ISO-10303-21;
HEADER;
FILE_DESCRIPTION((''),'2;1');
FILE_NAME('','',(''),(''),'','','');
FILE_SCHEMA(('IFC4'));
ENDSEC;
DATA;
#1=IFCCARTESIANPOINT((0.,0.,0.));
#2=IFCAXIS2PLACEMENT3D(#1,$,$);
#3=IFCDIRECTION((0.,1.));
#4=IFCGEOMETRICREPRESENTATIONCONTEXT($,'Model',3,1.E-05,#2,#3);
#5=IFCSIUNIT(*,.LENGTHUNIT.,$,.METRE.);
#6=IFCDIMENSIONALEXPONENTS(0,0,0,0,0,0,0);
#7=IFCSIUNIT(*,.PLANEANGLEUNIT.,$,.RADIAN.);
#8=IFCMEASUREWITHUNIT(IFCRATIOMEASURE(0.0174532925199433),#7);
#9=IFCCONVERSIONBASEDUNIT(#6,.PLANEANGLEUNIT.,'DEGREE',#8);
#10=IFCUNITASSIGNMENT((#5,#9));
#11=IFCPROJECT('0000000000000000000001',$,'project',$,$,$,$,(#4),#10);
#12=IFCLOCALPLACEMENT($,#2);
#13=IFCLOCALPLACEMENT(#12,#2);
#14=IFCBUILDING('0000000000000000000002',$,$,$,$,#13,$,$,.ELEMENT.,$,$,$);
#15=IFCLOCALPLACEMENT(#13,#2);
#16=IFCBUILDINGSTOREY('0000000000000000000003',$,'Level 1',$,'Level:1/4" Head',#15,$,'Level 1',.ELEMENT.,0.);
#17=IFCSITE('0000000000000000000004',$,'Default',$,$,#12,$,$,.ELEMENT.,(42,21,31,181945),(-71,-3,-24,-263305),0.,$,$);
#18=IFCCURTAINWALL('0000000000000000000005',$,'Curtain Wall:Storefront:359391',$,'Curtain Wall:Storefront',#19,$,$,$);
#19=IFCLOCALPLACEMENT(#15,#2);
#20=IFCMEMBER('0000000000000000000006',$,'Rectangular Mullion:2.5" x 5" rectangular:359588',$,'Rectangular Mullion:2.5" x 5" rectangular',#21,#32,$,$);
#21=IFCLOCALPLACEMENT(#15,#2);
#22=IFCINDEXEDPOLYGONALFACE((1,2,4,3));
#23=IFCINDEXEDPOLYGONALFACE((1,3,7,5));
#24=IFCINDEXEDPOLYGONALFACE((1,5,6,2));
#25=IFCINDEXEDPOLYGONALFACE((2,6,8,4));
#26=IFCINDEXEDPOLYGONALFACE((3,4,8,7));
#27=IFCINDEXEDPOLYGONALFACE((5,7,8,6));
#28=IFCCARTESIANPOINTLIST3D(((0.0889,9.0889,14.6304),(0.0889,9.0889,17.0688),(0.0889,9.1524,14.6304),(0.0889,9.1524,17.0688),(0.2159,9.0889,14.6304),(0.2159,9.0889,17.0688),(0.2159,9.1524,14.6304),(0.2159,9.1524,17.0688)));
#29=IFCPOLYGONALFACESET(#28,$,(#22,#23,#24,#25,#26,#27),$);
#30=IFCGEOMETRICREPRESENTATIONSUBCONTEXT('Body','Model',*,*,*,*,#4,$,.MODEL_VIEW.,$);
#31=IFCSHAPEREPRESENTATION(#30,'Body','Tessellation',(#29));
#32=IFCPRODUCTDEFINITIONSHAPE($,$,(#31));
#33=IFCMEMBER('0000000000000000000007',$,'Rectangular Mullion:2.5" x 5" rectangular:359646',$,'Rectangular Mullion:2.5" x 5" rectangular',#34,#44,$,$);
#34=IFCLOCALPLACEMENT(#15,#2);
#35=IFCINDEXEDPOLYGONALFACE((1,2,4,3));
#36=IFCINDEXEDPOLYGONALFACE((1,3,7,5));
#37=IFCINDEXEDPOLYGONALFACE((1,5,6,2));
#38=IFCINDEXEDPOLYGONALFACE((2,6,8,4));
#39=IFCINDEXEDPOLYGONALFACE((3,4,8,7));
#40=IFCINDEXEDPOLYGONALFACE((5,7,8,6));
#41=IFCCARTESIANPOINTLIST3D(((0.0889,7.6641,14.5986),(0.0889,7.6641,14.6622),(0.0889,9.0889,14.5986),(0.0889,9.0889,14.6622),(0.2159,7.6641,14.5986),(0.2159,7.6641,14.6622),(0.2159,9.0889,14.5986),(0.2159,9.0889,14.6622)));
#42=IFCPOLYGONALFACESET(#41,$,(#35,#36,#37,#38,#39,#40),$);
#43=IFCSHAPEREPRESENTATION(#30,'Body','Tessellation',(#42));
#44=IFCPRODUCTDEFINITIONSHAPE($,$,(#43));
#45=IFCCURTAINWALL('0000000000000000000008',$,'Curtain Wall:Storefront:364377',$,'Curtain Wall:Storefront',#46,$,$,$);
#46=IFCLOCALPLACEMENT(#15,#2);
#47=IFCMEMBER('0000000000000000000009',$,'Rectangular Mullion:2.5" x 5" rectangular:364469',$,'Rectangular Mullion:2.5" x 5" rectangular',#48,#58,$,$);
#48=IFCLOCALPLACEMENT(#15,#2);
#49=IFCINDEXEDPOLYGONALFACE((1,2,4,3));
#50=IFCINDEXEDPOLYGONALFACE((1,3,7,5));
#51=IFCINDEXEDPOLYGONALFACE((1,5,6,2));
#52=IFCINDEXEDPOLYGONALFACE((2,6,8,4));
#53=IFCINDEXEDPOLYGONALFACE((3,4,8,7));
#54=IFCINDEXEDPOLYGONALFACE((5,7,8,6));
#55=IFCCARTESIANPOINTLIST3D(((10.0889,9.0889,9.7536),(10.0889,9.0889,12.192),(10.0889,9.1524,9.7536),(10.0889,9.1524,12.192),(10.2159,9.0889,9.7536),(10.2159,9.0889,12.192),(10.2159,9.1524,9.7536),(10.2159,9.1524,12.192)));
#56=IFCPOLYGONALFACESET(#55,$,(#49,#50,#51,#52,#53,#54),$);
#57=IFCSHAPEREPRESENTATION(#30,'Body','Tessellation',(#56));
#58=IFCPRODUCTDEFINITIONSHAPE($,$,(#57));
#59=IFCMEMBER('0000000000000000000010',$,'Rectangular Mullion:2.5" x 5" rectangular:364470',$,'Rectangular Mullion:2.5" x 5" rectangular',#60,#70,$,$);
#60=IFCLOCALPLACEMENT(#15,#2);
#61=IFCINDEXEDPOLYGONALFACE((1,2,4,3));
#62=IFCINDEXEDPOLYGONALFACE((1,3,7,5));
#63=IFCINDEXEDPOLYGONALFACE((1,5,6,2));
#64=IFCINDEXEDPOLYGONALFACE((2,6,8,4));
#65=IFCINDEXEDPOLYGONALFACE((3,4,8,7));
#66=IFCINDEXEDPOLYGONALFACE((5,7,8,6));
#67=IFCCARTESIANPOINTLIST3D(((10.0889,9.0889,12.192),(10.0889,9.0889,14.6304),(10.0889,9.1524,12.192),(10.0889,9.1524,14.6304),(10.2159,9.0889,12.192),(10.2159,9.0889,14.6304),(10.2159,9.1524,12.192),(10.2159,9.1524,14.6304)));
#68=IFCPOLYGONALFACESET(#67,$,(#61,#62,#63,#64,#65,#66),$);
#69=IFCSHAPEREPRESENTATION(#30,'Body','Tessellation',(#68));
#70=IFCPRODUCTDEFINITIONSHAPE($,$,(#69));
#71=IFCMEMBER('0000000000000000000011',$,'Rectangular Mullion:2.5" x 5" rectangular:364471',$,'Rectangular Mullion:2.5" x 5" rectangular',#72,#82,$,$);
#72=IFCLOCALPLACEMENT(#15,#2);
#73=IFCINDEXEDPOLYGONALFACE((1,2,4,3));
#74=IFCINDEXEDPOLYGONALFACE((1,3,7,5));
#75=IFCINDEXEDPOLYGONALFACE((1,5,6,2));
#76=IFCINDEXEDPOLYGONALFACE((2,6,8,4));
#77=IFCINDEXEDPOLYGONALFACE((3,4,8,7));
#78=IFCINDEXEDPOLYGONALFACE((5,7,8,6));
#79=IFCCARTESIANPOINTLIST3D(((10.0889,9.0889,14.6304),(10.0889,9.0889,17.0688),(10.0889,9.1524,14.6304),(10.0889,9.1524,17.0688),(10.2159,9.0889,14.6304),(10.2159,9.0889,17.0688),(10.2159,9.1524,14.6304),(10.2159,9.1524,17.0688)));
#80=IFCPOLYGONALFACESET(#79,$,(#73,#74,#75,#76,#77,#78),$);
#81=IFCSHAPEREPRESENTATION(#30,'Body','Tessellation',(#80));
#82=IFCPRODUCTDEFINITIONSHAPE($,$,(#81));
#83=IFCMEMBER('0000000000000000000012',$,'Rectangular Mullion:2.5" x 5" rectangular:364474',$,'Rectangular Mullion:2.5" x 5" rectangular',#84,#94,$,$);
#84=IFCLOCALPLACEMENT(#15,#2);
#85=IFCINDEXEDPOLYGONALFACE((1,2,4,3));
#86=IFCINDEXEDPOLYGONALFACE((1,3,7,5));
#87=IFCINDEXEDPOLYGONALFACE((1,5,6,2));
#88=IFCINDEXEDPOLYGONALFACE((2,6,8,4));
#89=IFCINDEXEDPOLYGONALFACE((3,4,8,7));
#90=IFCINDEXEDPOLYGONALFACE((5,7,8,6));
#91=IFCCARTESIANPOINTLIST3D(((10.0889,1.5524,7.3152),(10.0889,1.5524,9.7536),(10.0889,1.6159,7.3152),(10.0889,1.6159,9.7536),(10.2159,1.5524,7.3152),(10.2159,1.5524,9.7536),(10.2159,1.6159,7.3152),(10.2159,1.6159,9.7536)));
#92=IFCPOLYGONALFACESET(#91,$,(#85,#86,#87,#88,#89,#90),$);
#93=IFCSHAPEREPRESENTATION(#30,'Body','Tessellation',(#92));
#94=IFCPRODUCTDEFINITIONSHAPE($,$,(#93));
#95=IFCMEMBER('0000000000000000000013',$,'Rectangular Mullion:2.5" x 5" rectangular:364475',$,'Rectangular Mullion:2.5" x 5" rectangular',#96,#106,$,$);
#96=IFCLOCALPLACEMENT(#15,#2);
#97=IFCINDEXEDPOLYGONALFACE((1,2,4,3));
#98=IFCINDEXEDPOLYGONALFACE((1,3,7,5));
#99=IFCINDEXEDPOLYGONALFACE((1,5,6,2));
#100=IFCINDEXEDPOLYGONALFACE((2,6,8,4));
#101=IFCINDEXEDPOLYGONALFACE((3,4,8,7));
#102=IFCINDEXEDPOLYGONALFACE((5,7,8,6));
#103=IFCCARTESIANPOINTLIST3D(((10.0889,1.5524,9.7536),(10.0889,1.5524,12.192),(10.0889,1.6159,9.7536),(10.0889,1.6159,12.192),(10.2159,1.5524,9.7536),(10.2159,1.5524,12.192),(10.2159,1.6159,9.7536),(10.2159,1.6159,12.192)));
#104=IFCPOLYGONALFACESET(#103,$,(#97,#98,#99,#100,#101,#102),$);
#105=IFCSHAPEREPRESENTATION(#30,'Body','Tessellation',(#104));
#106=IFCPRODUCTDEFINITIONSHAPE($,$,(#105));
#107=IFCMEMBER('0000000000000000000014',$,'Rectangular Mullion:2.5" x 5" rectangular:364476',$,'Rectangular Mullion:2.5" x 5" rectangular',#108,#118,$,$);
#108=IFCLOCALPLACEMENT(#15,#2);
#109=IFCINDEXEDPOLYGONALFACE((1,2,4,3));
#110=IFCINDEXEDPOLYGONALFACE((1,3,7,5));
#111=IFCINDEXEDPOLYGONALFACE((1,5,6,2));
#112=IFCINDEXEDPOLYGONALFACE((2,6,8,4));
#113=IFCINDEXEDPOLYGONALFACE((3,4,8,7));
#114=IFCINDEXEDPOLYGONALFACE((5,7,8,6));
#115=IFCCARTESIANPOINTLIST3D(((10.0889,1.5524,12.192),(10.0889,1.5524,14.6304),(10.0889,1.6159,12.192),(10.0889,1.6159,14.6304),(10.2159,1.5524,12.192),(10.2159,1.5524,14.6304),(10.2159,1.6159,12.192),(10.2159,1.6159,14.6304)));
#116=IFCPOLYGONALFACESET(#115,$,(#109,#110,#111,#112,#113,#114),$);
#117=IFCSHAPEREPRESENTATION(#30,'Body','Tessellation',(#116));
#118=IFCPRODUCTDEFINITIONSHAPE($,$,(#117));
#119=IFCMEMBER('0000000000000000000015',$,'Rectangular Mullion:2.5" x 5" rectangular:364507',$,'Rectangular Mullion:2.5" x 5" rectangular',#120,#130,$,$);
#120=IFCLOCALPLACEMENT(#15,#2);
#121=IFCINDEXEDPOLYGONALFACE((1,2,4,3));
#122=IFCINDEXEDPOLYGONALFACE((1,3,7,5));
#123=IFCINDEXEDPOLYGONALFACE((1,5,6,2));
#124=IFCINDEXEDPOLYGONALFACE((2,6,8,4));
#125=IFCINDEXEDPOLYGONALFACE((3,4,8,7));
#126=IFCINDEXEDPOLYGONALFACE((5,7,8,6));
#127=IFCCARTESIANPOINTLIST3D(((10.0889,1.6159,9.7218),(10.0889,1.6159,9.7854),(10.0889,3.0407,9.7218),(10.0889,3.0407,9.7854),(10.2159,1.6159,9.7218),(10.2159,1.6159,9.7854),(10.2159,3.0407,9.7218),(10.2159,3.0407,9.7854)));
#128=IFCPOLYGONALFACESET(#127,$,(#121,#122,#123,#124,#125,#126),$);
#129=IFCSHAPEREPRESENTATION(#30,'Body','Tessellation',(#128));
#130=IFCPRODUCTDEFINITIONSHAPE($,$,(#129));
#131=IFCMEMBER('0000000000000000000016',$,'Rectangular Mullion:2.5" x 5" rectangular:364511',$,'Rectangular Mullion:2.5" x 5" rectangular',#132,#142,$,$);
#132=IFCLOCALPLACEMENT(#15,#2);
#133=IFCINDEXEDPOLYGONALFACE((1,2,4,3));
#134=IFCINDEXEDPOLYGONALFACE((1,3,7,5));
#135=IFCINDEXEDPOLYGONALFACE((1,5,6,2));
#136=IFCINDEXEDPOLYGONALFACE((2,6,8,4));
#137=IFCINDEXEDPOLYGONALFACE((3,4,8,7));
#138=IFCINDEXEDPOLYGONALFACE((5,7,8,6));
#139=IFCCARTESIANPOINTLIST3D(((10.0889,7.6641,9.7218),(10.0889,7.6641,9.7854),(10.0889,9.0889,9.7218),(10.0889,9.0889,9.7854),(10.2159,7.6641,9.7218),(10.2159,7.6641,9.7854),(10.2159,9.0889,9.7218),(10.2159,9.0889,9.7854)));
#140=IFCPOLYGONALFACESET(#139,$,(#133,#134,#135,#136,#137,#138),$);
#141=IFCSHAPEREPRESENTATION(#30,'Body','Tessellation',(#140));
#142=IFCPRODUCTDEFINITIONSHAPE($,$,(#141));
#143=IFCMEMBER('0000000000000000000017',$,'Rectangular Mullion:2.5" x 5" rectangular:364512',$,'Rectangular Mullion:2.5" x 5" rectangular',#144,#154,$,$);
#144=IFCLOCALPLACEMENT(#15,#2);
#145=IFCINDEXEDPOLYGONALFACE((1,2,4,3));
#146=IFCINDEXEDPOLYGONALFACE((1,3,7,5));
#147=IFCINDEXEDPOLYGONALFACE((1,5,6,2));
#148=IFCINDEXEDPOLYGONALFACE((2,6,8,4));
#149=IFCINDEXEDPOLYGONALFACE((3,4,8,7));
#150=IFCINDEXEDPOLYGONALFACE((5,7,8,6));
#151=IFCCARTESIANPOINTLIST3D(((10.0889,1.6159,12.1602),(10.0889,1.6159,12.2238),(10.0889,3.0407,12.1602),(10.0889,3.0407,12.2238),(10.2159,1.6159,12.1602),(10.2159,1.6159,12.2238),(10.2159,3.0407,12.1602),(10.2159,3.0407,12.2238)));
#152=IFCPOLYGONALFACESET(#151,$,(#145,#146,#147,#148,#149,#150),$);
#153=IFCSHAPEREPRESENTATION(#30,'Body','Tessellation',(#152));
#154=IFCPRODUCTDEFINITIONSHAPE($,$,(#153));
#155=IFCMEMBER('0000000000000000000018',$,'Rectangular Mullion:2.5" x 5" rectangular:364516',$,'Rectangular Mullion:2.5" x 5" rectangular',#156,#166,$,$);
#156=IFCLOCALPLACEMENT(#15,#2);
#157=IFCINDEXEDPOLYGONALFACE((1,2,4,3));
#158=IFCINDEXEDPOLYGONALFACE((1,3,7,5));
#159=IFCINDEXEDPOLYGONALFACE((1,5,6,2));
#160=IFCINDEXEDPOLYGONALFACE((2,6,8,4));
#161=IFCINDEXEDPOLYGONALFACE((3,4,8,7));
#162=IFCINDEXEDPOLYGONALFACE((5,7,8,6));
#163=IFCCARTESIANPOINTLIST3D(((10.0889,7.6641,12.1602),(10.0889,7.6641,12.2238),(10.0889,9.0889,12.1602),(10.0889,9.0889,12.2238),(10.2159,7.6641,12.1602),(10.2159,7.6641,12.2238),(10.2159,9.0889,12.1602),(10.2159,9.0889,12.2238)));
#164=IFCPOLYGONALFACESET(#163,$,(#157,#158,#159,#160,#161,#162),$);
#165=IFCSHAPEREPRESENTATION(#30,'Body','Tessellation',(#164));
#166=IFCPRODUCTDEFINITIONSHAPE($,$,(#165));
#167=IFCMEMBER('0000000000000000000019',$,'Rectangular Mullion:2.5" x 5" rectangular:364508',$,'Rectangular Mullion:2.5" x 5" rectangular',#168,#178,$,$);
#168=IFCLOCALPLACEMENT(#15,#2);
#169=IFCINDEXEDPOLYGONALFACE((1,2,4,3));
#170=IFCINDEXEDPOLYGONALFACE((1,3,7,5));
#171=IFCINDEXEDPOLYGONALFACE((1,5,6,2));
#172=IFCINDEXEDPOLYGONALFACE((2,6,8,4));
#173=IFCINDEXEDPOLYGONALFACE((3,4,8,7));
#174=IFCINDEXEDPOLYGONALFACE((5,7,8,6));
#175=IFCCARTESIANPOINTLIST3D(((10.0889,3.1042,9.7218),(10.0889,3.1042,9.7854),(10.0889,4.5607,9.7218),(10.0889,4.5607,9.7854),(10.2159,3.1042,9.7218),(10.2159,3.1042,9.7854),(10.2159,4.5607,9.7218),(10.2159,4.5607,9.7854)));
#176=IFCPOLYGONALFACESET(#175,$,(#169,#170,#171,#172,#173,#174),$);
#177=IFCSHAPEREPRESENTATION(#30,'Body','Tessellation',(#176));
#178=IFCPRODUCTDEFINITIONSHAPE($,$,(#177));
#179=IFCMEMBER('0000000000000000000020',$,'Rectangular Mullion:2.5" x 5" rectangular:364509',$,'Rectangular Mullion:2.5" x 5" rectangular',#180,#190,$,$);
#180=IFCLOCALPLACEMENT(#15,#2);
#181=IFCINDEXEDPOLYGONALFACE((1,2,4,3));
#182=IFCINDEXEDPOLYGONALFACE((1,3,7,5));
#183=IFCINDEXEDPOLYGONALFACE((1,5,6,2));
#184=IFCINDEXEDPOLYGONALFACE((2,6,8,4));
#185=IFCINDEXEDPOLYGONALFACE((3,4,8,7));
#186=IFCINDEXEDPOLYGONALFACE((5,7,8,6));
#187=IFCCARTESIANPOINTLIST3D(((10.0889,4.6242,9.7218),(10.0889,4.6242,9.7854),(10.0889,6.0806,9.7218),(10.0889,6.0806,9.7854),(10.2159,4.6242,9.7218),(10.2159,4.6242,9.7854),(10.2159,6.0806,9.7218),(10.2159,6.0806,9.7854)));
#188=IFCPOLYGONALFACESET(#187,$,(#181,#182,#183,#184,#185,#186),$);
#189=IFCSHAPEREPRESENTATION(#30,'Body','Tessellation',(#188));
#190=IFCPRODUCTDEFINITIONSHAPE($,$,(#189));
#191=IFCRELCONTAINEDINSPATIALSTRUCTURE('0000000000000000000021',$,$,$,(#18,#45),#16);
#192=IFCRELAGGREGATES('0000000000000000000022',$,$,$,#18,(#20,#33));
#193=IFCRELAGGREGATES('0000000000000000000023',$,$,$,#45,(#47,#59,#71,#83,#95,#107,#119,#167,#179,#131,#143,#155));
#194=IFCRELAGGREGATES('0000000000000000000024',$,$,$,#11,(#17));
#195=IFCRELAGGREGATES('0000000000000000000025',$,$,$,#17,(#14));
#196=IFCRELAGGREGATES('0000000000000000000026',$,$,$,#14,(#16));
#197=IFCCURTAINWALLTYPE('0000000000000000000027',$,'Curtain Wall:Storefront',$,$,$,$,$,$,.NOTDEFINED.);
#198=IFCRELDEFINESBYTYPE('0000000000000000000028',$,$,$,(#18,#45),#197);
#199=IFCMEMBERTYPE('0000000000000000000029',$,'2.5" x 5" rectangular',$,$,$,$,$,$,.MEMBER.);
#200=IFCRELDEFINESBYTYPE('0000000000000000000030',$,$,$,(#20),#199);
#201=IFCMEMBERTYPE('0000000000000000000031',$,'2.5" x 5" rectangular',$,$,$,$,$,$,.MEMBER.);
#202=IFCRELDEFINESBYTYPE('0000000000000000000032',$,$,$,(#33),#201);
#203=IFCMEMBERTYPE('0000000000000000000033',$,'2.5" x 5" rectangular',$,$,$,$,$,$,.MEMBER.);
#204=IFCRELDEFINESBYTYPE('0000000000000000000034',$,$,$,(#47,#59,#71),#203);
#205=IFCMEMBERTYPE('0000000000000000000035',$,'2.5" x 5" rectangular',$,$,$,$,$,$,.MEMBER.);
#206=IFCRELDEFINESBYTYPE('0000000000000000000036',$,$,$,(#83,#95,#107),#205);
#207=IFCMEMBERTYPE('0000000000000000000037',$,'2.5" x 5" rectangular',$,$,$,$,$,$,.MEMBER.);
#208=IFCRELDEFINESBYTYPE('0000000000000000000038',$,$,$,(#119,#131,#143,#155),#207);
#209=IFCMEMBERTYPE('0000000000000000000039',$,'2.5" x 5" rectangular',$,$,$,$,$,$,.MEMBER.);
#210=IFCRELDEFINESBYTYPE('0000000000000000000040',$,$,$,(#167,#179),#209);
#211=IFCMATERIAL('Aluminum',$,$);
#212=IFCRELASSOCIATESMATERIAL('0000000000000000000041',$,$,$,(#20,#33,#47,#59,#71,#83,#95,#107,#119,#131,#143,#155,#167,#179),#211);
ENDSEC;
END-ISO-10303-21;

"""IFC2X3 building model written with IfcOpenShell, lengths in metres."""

from ifc_helpers import new_model, entity, si_unit, converted_unit, direction, frame, origin, origin_2d_with_axis, place, context, subcontext, project, spatial, rectangle, extrude, source, transform, mapped, material, type_object, type_shapes, element, aggregate, save


model = new_model("IFC2X3")

# Units and contexts
model_context = context("Model", 3, precision=1e-05, world=origin(), true_north=direction((0.0, 1.0)))
body_context = subcontext(model_context, "Body", "Model", "MODEL_VIEW")
ifc_project = project(units=[si_unit("LENGTHUNIT", "METRE"), converted_unit("PLANEANGLEUNIT", "DEGREE", entity("IfcRatioMeasure", 0.0174532925199433), si_unit("PLANEANGLEUNIT", "RADIAN"), dimensions=[0, 0, 0, 0, 0, 0, 0])], contexts=[model_context])

# Site, building, storey
site_placement = place(None, origin())
site = spatial("IfcSite", under=ifc_project, at=site_placement, Name="Default", CompositionType="ELEMENT", RefLatitude=(42, 21, 31, 181945), RefLongitude=(-71, -3, -24, -263305), RefElevation=0.0)
building_placement = place(site_placement, origin())
building = spatial("IfcBuilding", under=site, at=building_placement, CompositionType="ELEMENT")
storey_placement = place(building_placement, origin())
storey = spatial("IfcBuildingStorey", under=building, at=storey_placement, Name="Level 1", ObjectType="Level:1/4\" Head", LongName="Level 1", CompositionType="ELEMENT", Elevation=0.0)

# Curtain wall, members
curtain_wall_type = type_object("IfcCurtainWallType", Name="Curtain Wall:Storefront", PredefinedType="NOTDEFINED")
curtain_wall_1_placement = place(storey_placement, origin())
curtain_wall_1 = element("IfcCurtainWall", 1, at=curtain_wall_1_placement, inside=storey, type_object=curtain_wall_type, Name="Curtain Wall:Storefront:359391", ObjectType="Curtain Wall:Storefront")
ifc_material_1 = material(Name="Aluminum")
member_type_1 = type_object("IfcMemberType", Name="2.5\" x 5\" rectangular", PredefinedType="MEMBER")
shared_shape_1 = source(origin(), body_context, "Body", "SweptSolid", [
    extrude(rectangle(XDim=0.127, YDim=0.0635, at=origin_2d_with_axis()), frame((-0.0318, 0.0, -2.4384), z_axis=(0.0, 0.0, 1.0), x_axis=(0.0, -1.0, 0.0)), (0.0, 0.0, 1.0), 2.4384),
])
type_shapes(member_type_1, [shared_shape_1])
member_1_placement = place(storey_placement, frame((0.1524, 9.1524, 14.6304), z_axis=(0.0, 0.0, -1.0), x_axis=(0.0, 1.0, 0.0)))
member_1 = element("IfcMember", 2, at=member_1_placement, type_object=member_type_1, material=ifc_material_1, Name="Rectangular Mullion:2.5\" x 5\" rectangular:359588", ObjectType="Rectangular Mullion:2.5\" x 5\" rectangular", context=body_context, shape_type="MappedRepresentation", body=[
    mapped(shared_shape_1, transform((0.0, 0.0, 0.0), scale=1.0)),
])
member_type_2 = type_object("IfcMemberType", Name="2.5\" x 5\" rectangular", PredefinedType="MEMBER")
shared_shape_2 = source(origin(), body_context, "Body", "SweptSolid", [
    extrude(rectangle(XDim=0.127, YDim=0.0635, at=origin_2d_with_axis()), frame((0.0, 0.0, -1.4248), z_axis=(0.0, 0.0, 1.0), x_axis=(0.0, -1.0, 0.0)), (0.0, 0.0, 1.0), 1.4248),
])
type_shapes(member_type_2, [shared_shape_2])
member_2_placement = place(storey_placement, frame((0.1524, 9.0889, 14.6304), z_axis=(0.0, 1.0, 0.0), x_axis=(0.0, 0.0, 1.0)))
member_2 = element("IfcMember", 3, at=member_2_placement, type_object=member_type_2, material=ifc_material_1, Name="Rectangular Mullion:2.5\" x 5\" rectangular:359646", ObjectType="Rectangular Mullion:2.5\" x 5\" rectangular", context=body_context, shape_type="MappedRepresentation", body=[
    mapped(shared_shape_2, transform((0.0, 0.0, 0.0), scale=1.0)),
])
aggregate(curtain_wall_1, [member_1, member_2])

# Curtain wall, members
curtain_wall_2_placement = place(storey_placement, origin())
curtain_wall_2 = element("IfcCurtainWall", 4, at=curtain_wall_2_placement, inside=storey, type_object=curtain_wall_type, Name="Curtain Wall:Storefront:364377", ObjectType="Curtain Wall:Storefront")
member_type_3 = type_object("IfcMemberType", Name="2.5\" x 5\" rectangular", PredefinedType="MEMBER")
shared_shape_3 = source(origin(), body_context, "Body", "SweptSolid", [
    extrude(rectangle(XDim=0.127, YDim=0.0635, at=origin_2d_with_axis()), frame((-0.0318, 0.0, -2.4384), z_axis=(0.0, 0.0, 1.0), x_axis=(0.0, -1.0, 0.0)), (0.0, 0.0, 1.0), 2.4384),
])
type_shapes(member_type_3, [shared_shape_3])
member_3_placement = place(storey_placement, frame((10.1524, 9.1524, 9.7536), z_axis=(0.0, 0.0, -1.0), x_axis=(0.0, 1.0, 0.0)))
member_3 = element("IfcMember", 5, at=member_3_placement, type_object=member_type_3, material=ifc_material_1, Name="Rectangular Mullion:2.5\" x 5\" rectangular:364469", ObjectType="Rectangular Mullion:2.5\" x 5\" rectangular", context=body_context, shape_type="MappedRepresentation", body=[
    mapped(shared_shape_3, transform((0.0, 0.0, 0.0), scale=1.0)),
])
member_4_placement = place(storey_placement, frame((10.1524, 9.1524, 12.192), z_axis=(0.0, 0.0, -1.0), x_axis=(0.0, 1.0, 0.0)))
member_4 = element("IfcMember", 6, at=member_4_placement, type_object=member_type_3, material=ifc_material_1, Name="Rectangular Mullion:2.5\" x 5\" rectangular:364470", ObjectType="Rectangular Mullion:2.5\" x 5\" rectangular", context=body_context, shape_type="MappedRepresentation", body=[
    mapped(shared_shape_3, transform((0.0, 0.0, 0.0), scale=1.0)),
])
member_5_placement = place(storey_placement, frame((10.1524, 9.1524, 14.6304), z_axis=(0.0, 0.0, -1.0), x_axis=(0.0, 1.0, 0.0)))
member_5 = element("IfcMember", 7, at=member_5_placement, type_object=member_type_3, material=ifc_material_1, Name="Rectangular Mullion:2.5\" x 5\" rectangular:364471", ObjectType="Rectangular Mullion:2.5\" x 5\" rectangular", context=body_context, shape_type="MappedRepresentation", body=[
    mapped(shared_shape_3, transform((0.0, 0.0, 0.0), scale=1.0)),
])
member_type_4 = type_object("IfcMemberType", Name="2.5\" x 5\" rectangular", PredefinedType="MEMBER")
shared_shape_4 = source(origin(), body_context, "Body", "SweptSolid", [
    extrude(rectangle(XDim=0.127, YDim=0.0635, at=origin_2d_with_axis()), frame((-0.0318, 0.0, -2.4384), z_axis=(0.0, 0.0, 1.0), x_axis=(0.0, -1.0, 0.0)), (0.0, 0.0, 1.0), 2.4384),
])
type_shapes(member_type_4, [shared_shape_4])
member_6_placement = place(storey_placement, frame((10.1524, 1.5524, 9.7536), z_axis=(0.0, 0.0, 1.0), x_axis=(0.0, -1.0, 0.0)))
member_6 = element("IfcMember", 8, at=member_6_placement, type_object=member_type_4, material=ifc_material_1, Name="Rectangular Mullion:2.5\" x 5\" rectangular:364474", ObjectType="Rectangular Mullion:2.5\" x 5\" rectangular", context=body_context, shape_type="MappedRepresentation", body=[
    mapped(shared_shape_4, transform((0.0, 0.0, 0.0), scale=1.0)),
])
member_7_placement = place(storey_placement, frame((10.1524, 1.5524, 12.192), z_axis=(0.0, 0.0, 1.0), x_axis=(0.0, -1.0, 0.0)))
member_7 = element("IfcMember", 9, at=member_7_placement, type_object=member_type_4, material=ifc_material_1, Name="Rectangular Mullion:2.5\" x 5\" rectangular:364475", ObjectType="Rectangular Mullion:2.5\" x 5\" rectangular", context=body_context, shape_type="MappedRepresentation", body=[
    mapped(shared_shape_4, transform((0.0, 0.0, 0.0), scale=1.0)),
])
member_8_placement = place(storey_placement, frame((10.1524, 1.5524, 14.6304), z_axis=(0.0, 0.0, 1.0), x_axis=(0.0, -1.0, 0.0)))
member_8 = element("IfcMember", 10, at=member_8_placement, type_object=member_type_4, material=ifc_material_1, Name="Rectangular Mullion:2.5\" x 5\" rectangular:364476", ObjectType="Rectangular Mullion:2.5\" x 5\" rectangular", context=body_context, shape_type="MappedRepresentation", body=[
    mapped(shared_shape_4, transform((0.0, 0.0, 0.0), scale=1.0)),
])
member_type_5 = type_object("IfcMemberType", Name="2.5\" x 5\" rectangular", PredefinedType="MEMBER")
shared_shape_5 = source(origin(), body_context, "Body", "SweptSolid", [
    extrude(rectangle(XDim=0.127, YDim=0.0635, at=origin_2d_with_axis()), frame((0.0, 0.0, -1.4248), z_axis=(0.0, 0.0, 1.0), x_axis=(0.0, -1.0, 0.0)), (0.0, 0.0, 1.0), 1.4248),
])
type_shapes(member_type_5, [shared_shape_5])
member_9_placement = place(storey_placement, frame((10.1524, 3.0407, 9.7536), z_axis=(0.0, 1.0, 0.0), x_axis=(0.0, 0.0, 1.0)))
member_9 = element("IfcMember", 11, at=member_9_placement, type_object=member_type_5, material=ifc_material_1, Name="Rectangular Mullion:2.5\" x 5\" rectangular:364507", ObjectType="Rectangular Mullion:2.5\" x 5\" rectangular", context=body_context, shape_type="MappedRepresentation", body=[
    mapped(shared_shape_5, transform((0.0, 0.0, 0.0), scale=1.0)),
])
member_10_placement = place(storey_placement, frame((10.1524, 9.0889, 9.7536), z_axis=(0.0, 1.0, 0.0), x_axis=(0.0, 0.0, 1.0)))
member_10 = element("IfcMember", 12, at=member_10_placement, type_object=member_type_5, material=ifc_material_1, Name="Rectangular Mullion:2.5\" x 5\" rectangular:364511", ObjectType="Rectangular Mullion:2.5\" x 5\" rectangular", context=body_context, shape_type="MappedRepresentation", body=[
    mapped(shared_shape_5, transform((0.0, 0.0, 0.0), scale=1.0)),
])
member_11_placement = place(storey_placement, frame((10.1524, 3.0407, 12.192), z_axis=(0.0, 1.0, 0.0), x_axis=(0.0, 0.0, 1.0)))
member_11 = element("IfcMember", 13, at=member_11_placement, type_object=member_type_5, material=ifc_material_1, Name="Rectangular Mullion:2.5\" x 5\" rectangular:364512", ObjectType="Rectangular Mullion:2.5\" x 5\" rectangular", context=body_context, shape_type="MappedRepresentation", body=[
    mapped(shared_shape_5, transform((0.0, 0.0, 0.0), scale=1.0)),
])
member_12_placement = place(storey_placement, frame((10.1524, 9.0889, 12.192), z_axis=(0.0, 1.0, 0.0), x_axis=(0.0, 0.0, 1.0)))
member_12 = element("IfcMember", 14, at=member_12_placement, type_object=member_type_5, material=ifc_material_1, Name="Rectangular Mullion:2.5\" x 5\" rectangular:364516", ObjectType="Rectangular Mullion:2.5\" x 5\" rectangular", context=body_context, shape_type="MappedRepresentation", body=[
    mapped(shared_shape_5, transform((0.0, 0.0, 0.0), scale=1.0)),
])
member_type_6 = type_object("IfcMemberType", Name="2.5\" x 5\" rectangular", PredefinedType="MEMBER")
shared_shape_6 = source(origin(), body_context, "Body", "SweptSolid", [
    extrude(rectangle(XDim=0.127, YDim=0.0635, at=origin_2d_with_axis()), frame((0.0, 0.0, -1.4565), z_axis=(0.0, 0.0, 1.0), x_axis=(0.0, -1.0, 0.0)), (0.0, 0.0, 1.0), 1.4565),
])
type_shapes(member_type_6, [shared_shape_6])
member_13_placement = place(storey_placement, frame((10.1524, 4.5607, 9.7536), z_axis=(0.0, 1.0, 0.0), x_axis=(0.0, 0.0, 1.0)))
member_13 = element("IfcMember", 15, at=member_13_placement, type_object=member_type_6, material=ifc_material_1, Name="Rectangular Mullion:2.5\" x 5\" rectangular:364508", ObjectType="Rectangular Mullion:2.5\" x 5\" rectangular", context=body_context, shape_type="MappedRepresentation", body=[
    mapped(shared_shape_6, transform((0.0, 0.0, 0.0), scale=1.0)),
])
member_14_placement = place(storey_placement, frame((10.1524, 6.0806, 9.7536), z_axis=(0.0, 1.0, 0.0), x_axis=(0.0, 0.0, 1.0)))
member_14 = element("IfcMember", 16, at=member_14_placement, type_object=member_type_6, material=ifc_material_1, Name="Rectangular Mullion:2.5\" x 5\" rectangular:364509", ObjectType="Rectangular Mullion:2.5\" x 5\" rectangular", context=body_context, shape_type="MappedRepresentation", body=[
    mapped(shared_shape_6, transform((0.0, 0.0, 0.0), scale=1.0)),
])
aggregate(curtain_wall_2, [member_3, member_4, member_5, member_6, member_7, member_8, member_9, member_13, member_14, member_10, member_11, member_12])

save(model, "model.ifc")
